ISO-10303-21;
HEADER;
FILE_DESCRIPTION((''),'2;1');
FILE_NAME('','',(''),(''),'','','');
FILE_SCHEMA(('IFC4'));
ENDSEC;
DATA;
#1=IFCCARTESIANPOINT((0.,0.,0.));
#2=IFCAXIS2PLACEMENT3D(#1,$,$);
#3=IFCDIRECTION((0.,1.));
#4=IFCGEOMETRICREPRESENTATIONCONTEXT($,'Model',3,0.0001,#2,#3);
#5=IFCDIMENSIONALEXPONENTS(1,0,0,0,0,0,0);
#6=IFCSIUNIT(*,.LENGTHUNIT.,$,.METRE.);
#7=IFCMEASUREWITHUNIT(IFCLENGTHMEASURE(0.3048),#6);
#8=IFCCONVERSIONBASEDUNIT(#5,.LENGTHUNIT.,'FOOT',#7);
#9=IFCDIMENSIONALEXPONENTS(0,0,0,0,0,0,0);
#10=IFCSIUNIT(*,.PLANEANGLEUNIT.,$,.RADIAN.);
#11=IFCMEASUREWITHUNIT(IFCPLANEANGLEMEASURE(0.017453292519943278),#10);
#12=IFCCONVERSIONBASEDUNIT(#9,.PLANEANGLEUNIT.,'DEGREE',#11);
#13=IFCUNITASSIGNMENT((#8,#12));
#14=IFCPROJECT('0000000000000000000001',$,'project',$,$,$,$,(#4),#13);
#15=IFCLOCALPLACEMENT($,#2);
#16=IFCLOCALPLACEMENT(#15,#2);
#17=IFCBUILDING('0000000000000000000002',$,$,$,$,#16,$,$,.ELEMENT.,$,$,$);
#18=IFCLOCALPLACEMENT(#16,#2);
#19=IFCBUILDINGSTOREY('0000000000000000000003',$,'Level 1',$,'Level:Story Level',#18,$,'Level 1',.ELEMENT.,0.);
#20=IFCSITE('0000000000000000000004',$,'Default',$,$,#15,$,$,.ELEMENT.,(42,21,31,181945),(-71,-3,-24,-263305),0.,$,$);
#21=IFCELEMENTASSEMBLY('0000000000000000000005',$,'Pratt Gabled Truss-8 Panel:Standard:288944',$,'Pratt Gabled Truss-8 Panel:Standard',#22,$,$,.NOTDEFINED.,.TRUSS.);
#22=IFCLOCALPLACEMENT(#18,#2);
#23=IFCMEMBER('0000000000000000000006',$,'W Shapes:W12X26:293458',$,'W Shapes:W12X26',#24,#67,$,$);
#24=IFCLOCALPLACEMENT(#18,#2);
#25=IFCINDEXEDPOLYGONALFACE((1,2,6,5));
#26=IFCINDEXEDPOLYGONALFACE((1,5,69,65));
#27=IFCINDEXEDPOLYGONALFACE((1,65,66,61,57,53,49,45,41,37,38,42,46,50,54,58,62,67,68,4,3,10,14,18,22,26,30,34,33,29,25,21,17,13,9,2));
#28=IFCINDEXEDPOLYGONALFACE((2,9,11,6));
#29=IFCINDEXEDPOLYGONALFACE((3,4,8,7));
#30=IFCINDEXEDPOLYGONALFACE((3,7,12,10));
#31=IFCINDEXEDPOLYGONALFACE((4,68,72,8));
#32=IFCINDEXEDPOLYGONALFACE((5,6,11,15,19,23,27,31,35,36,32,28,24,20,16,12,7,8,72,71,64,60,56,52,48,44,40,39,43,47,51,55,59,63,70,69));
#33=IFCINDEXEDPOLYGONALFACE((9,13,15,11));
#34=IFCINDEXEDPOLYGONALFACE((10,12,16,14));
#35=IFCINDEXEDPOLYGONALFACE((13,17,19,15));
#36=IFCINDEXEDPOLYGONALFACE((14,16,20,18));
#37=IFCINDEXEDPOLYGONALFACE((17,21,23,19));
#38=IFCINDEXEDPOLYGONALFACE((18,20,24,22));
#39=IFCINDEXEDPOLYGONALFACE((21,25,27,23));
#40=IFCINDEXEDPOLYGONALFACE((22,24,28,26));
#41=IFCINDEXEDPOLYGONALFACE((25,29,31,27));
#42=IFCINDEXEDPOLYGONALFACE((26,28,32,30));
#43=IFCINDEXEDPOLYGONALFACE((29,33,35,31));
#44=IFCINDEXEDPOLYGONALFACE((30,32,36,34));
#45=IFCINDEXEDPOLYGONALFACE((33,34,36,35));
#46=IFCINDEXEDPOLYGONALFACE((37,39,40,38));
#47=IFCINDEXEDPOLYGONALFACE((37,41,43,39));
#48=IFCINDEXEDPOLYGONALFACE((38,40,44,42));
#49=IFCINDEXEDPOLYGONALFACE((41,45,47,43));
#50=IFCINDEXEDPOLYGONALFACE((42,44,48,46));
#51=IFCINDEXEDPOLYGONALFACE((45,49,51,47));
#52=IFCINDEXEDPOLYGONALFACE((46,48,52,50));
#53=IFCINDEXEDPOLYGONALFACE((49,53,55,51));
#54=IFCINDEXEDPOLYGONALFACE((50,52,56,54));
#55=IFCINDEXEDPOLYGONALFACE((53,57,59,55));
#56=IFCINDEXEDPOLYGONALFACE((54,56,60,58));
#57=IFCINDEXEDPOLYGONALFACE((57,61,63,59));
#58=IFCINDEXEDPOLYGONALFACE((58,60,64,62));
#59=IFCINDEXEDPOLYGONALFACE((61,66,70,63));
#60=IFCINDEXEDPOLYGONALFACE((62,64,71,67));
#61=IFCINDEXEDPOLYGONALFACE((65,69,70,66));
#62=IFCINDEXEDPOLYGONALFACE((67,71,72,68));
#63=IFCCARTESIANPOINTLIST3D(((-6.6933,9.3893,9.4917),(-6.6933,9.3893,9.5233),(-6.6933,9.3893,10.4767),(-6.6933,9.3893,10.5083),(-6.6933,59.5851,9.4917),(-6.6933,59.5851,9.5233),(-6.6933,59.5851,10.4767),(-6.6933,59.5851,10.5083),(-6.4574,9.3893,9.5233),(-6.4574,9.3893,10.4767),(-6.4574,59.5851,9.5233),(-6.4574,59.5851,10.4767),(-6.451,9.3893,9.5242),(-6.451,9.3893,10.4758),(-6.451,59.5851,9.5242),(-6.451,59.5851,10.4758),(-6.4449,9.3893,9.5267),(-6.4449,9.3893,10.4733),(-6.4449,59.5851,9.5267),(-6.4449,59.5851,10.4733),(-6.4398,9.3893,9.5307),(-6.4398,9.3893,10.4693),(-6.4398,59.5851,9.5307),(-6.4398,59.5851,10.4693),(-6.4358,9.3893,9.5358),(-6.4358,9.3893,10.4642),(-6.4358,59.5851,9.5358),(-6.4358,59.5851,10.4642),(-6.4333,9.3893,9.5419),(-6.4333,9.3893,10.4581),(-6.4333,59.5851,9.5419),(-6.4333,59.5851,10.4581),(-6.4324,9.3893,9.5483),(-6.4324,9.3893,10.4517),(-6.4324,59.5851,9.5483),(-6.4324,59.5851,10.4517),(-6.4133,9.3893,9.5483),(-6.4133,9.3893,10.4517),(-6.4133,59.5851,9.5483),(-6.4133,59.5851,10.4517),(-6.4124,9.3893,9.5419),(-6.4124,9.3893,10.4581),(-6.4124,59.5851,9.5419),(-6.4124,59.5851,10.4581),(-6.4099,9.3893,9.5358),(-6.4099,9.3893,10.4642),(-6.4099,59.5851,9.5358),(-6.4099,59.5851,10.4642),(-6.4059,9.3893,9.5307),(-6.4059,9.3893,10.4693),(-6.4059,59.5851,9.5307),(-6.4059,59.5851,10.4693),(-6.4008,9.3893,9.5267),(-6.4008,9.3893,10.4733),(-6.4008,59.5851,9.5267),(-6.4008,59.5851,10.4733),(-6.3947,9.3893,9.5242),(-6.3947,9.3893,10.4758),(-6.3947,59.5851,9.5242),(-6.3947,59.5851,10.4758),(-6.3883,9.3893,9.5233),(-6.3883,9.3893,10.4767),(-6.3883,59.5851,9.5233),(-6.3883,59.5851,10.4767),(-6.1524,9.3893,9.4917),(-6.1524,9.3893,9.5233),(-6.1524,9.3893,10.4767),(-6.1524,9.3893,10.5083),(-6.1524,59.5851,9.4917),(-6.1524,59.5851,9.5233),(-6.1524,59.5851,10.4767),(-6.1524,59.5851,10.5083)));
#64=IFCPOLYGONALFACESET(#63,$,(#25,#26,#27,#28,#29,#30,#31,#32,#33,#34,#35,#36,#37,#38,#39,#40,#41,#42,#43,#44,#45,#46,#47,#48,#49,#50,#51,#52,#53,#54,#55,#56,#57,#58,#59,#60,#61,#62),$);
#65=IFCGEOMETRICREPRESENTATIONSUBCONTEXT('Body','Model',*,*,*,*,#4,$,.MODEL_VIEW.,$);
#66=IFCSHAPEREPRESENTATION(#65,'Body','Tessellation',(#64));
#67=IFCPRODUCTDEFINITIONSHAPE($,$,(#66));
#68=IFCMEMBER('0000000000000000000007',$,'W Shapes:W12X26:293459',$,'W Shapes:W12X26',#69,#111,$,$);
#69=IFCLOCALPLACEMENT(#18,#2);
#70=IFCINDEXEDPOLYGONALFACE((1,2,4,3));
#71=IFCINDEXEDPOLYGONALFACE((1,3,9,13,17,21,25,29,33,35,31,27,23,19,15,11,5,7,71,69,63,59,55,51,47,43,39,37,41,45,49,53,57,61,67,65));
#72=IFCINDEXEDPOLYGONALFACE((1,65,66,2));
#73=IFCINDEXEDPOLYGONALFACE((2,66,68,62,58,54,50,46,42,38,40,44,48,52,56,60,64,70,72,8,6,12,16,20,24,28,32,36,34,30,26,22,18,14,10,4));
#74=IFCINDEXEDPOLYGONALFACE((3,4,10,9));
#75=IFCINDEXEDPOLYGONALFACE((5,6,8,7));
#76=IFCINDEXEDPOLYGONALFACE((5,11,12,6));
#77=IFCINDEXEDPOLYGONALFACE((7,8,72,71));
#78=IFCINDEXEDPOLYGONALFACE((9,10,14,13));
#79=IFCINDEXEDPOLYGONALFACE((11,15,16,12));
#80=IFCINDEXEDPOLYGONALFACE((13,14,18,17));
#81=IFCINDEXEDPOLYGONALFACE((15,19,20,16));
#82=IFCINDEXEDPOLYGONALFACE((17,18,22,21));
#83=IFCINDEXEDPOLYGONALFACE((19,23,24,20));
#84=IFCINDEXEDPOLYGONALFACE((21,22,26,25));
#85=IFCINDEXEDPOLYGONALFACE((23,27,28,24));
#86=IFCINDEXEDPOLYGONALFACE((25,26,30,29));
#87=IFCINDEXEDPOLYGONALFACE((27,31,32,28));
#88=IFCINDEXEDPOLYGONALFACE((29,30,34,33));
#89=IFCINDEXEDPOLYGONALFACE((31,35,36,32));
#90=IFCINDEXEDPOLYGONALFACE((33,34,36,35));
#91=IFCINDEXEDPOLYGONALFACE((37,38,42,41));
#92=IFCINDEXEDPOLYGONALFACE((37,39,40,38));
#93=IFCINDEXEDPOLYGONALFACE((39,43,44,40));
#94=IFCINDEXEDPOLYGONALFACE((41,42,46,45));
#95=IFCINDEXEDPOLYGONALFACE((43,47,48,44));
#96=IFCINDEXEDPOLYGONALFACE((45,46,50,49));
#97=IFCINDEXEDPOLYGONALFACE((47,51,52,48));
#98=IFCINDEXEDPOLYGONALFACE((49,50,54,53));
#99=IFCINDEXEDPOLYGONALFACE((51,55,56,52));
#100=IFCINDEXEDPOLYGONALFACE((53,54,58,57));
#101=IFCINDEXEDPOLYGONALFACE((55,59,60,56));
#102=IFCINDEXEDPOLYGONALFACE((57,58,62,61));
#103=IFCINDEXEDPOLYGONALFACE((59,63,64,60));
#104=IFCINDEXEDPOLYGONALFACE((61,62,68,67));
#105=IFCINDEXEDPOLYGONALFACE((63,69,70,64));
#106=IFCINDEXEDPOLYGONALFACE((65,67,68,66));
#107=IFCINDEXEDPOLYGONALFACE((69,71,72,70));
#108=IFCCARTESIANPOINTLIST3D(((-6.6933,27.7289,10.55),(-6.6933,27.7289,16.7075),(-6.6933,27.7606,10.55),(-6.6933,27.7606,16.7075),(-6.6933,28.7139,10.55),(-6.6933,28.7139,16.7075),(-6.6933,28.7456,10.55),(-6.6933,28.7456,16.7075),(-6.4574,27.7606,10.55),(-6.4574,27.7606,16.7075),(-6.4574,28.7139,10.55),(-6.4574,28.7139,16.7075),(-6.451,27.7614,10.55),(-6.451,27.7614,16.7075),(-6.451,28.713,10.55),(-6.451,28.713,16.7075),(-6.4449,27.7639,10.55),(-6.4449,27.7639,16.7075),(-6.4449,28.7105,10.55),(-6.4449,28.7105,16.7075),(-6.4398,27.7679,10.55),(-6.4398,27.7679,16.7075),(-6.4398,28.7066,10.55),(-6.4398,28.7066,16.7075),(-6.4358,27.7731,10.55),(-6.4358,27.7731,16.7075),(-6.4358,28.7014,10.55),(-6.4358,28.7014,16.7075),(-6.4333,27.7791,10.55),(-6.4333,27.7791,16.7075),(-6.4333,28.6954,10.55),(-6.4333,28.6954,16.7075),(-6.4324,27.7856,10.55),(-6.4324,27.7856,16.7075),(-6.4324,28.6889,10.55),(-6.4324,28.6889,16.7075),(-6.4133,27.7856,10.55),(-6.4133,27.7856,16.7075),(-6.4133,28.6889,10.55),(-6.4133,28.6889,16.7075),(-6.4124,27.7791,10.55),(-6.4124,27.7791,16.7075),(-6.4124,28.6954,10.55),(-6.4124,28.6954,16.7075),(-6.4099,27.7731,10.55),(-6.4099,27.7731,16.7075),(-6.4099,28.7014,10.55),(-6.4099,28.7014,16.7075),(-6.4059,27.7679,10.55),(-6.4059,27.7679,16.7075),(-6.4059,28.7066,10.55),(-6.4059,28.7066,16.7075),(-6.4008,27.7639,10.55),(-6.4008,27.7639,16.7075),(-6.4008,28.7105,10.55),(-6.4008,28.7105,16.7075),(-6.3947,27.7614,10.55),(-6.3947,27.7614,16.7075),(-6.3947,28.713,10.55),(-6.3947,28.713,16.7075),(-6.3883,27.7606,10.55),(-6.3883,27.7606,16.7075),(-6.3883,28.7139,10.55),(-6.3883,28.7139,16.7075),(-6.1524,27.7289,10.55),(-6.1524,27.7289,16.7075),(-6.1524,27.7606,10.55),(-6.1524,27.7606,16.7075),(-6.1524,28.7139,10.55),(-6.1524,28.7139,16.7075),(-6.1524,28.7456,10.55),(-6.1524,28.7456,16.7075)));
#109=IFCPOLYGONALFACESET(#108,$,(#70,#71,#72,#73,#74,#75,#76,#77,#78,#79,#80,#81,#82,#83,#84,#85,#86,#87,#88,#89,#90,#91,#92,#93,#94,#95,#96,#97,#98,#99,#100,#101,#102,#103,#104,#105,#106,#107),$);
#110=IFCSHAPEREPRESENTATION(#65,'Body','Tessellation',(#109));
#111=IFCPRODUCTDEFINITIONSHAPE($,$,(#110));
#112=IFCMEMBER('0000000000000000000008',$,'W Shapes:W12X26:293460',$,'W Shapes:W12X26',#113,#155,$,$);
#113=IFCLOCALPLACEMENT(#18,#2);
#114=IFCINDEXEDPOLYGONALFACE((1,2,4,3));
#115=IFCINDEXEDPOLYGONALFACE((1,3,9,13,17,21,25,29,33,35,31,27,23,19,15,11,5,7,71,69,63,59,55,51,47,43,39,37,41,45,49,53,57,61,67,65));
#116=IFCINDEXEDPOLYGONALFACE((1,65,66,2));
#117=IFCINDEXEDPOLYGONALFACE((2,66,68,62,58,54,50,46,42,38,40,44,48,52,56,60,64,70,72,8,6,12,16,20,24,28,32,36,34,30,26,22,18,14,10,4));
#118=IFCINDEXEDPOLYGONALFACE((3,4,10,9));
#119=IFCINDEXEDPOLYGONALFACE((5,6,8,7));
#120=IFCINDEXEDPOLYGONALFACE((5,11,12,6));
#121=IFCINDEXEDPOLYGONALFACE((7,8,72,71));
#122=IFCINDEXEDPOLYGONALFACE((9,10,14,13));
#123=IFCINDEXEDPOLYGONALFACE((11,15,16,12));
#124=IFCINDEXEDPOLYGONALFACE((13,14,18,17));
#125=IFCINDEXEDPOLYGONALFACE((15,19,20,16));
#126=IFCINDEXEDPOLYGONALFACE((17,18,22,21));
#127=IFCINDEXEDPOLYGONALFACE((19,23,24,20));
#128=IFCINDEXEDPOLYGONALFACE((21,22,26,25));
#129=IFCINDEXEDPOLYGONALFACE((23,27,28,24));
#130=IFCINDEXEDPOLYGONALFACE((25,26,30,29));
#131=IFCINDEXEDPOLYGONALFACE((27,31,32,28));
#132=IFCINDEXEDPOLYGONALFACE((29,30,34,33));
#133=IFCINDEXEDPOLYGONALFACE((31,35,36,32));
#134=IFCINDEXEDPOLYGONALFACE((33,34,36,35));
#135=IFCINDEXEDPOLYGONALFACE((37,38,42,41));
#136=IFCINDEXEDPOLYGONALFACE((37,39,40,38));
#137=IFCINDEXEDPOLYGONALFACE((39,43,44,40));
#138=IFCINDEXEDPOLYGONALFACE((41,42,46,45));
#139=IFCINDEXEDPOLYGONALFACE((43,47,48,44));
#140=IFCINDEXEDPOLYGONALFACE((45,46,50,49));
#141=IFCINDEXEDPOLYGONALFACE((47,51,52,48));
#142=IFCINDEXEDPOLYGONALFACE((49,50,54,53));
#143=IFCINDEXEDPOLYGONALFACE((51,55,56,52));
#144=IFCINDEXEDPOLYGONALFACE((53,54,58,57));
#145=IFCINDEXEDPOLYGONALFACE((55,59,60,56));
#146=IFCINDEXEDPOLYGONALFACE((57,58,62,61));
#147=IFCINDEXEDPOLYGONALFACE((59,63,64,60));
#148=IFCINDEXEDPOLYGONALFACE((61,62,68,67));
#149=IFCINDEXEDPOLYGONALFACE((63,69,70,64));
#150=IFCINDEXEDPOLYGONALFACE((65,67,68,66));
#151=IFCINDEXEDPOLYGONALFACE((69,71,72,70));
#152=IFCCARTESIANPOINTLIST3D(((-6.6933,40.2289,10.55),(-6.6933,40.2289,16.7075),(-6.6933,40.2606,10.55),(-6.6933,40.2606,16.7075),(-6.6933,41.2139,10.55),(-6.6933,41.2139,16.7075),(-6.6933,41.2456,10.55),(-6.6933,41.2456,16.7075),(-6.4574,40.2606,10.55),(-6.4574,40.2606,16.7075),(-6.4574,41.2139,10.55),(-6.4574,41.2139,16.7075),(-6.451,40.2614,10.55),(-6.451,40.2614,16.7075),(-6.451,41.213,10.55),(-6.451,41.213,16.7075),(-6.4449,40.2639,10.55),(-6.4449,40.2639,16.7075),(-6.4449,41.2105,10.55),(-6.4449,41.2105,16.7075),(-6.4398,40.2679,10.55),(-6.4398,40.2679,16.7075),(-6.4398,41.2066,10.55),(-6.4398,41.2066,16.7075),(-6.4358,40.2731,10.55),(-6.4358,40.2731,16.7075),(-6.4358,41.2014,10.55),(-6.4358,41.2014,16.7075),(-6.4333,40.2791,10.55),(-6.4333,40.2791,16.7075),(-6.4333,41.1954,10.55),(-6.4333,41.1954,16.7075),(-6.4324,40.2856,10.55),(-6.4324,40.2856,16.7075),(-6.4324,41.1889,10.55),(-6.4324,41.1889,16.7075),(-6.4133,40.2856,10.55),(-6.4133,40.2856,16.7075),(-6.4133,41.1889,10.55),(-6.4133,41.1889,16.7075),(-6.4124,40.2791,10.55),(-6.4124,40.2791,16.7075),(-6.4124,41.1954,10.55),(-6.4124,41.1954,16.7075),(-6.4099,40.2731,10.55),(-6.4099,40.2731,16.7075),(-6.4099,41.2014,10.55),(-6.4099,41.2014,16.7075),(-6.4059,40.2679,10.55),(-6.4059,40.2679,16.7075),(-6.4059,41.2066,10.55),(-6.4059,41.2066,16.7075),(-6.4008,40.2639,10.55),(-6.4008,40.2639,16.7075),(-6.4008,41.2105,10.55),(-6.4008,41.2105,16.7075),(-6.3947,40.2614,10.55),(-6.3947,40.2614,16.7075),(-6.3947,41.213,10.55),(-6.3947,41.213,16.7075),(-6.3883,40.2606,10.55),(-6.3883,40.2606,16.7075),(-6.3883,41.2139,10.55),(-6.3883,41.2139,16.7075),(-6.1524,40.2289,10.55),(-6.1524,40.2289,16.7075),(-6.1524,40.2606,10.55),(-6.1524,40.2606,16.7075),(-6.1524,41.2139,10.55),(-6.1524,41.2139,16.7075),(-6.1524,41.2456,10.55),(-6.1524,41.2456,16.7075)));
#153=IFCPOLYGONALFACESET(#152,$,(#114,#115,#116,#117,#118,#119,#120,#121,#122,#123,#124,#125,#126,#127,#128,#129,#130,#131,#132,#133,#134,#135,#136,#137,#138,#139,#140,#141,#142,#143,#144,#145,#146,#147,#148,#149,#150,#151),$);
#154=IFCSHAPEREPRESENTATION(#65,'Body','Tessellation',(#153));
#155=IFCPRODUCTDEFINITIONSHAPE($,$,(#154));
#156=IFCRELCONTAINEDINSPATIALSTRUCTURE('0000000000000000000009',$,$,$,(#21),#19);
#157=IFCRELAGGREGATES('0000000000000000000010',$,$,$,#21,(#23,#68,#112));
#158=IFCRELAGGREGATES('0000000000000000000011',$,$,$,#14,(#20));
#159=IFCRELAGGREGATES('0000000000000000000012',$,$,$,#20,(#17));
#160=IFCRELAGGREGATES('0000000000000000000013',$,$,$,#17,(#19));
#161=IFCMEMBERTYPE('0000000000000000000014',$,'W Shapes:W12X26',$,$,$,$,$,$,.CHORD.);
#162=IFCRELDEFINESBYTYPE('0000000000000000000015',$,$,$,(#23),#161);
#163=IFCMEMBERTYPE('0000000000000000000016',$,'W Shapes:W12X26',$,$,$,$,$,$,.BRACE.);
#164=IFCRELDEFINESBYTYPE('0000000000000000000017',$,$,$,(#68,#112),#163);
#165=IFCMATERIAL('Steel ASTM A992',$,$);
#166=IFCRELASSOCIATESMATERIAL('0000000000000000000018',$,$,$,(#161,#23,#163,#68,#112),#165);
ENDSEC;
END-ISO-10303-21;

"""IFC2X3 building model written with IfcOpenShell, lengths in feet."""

from ifc_helpers import new_model, entity, si_unit, converted_unit, direction, frame, frame_2d, origin, place, context, subcontext, project, spatial, polyline, circle_curve, parameter, trimmed, segment, composite_curve, outline, extrude, source, transform, mapped, material, type_object, type_shapes, element, aggregate, save


model = new_model("IFC2X3")

# Units and contexts
model_context = context("Model", 3, precision=0.0001, world=origin(), true_north=direction((0.0, 1.0)))
body_context = subcontext(model_context, "Body", "Model", "MODEL_VIEW")
ifc_project = project(units=[converted_unit("LENGTHUNIT", "FOOT", entity("IfcLengthMeasure", 0.3048), si_unit("LENGTHUNIT", "METRE"), dimensions=[1, 0, 0, 0, 0, 0, 0]), converted_unit("PLANEANGLEUNIT", "DEGREE", entity("IfcPlaneAngleMeasure", 0.017453292519943278), si_unit("PLANEANGLEUNIT", "RADIAN"), dimensions=[0, 0, 0, 0, 0, 0, 0])], contexts=[model_context])

# Site, building, storey
site_placement = place(None, origin())
site = spatial("IfcSite", under=ifc_project, at=site_placement, Name="Default", CompositionType="ELEMENT", RefLatitude=(42, 21, 31, 181945), RefLongitude=(-71, -3, -24, -263305), RefElevation=0.0)
building_placement = place(site_placement, origin())
building = spatial("IfcBuilding", under=site, at=building_placement, CompositionType="ELEMENT")
storey_placement = place(building_placement, origin())
storey = spatial("IfcBuildingStorey", under=building, at=storey_placement, Name="Level 1", ObjectType="Level:Story Level", LongName="Level 1", CompositionType="ELEMENT", Elevation=0.0)

# Element assembly, members
assembly_placement = place(storey_placement, origin())
assembly = element("IfcElementAssembly", 1, at=assembly_placement, inside=storey, Name="Pratt Gabled Truss-8 Panel:Standard:288944", ObjectType="Pratt Gabled Truss-8 Panel:Standard", AssemblyPlace="NOTDEFINED", PredefinedType="TRUSS")
ifc_material = material(Name="Steel ASTM A992")
member_type_1 = type_object("IfcMemberType", Name="W Shapes:W12X26", PredefinedType="CHORD", material=ifc_material)
shared_shape_1 = source(origin(), body_context, "Body", "SweptSolid", [
    extrude(outline(composite_curve([segment(polyline([(-0.2704, -0.4767), (-0.2704, -0.5083)]), True, "CONTINUOUS"), segment(polyline([(-0.2704, -0.5083), (0.2704, -0.5083)]), True, "CONTINUOUS"), segment(polyline([(0.2704, -0.5083), (0.2704, -0.4767)]), True, "CONTINUOUS"), segment(polyline([(0.2704, -0.4767), (0.0346, -0.4767)]), True, "CONTINUOUS"), segment(trimmed(circle_curve(frame_2d((0.0346, -0.4517), x_axis=(1.0, 0.0)), 0.025), [parameter(180.0)], [parameter(270.0)], True, "PARAMETER"), False, "CONTINUOUS"), segment(polyline([(0.0096, -0.4517), (0.0096, 0.4517)]), True, "CONTINUOUS"), segment(trimmed(circle_curve(frame_2d((0.0346, 0.4517), x_axis=(1.0, 0.0)), 0.025), [parameter(90.0)], [parameter(180.0)], True, "PARAMETER"), False, "CONTINUOUS"), segment(polyline([(0.0346, 0.4767), (0.2704, 0.4767)]), True, "CONTINUOUS"), segment(polyline([(0.2704, 0.4767), (0.2704, 0.5083)]), True, "CONTINUOUS"), segment(polyline([(0.2704, 0.5083), (-0.2704, 0.5083)]), True, "CONTINUOUS"), segment(polyline([(-0.2704, 0.5083), (-0.2704, 0.4767)]), True, "CONTINUOUS"), segment(polyline([(-0.2704, 0.4767), (-0.0346, 0.4767)]), True, "CONTINUOUS"), segment(trimmed(circle_curve(frame_2d((-0.0346, 0.4517), x_axis=(1.0, 0.0)), 0.025), [parameter(360.0)], [parameter(90.0)], True, "PARAMETER"), False, "CONTINUOUS"), segment(polyline([(-0.0096, 0.4517), (-0.0096, -0.4517)]), True, "CONTINUOUS"), segment(trimmed(circle_curve(frame_2d((-0.0346, -0.4517), x_axis=(1.0, 0.0)), 0.025), [parameter(270.0)], [parameter(360.0)], True, "PARAMETER"), False, "CONTINUOUS"), segment(polyline([(-0.0346, -0.4767), (-0.2704, -0.4767)]), True, "CONTINUOUS")], self_intersect=False)), frame((-25.0979, 0.0, 0.0), z_axis=(-1.0, 0.0, 0.0), x_axis=(0.0, -1.0, 0.0)), (0.0, 0.0, -1.0), 50.1958),
])
type_shapes(member_type_1, [shared_shape_1])
member_1_placement = place(assembly_placement, frame((-6.4228, 34.4872, 10.0), z_axis=(0.0, 0.0, 1.0), x_axis=(0.0, 1.0, 0.0)))
member_1 = element("IfcMember", 2, at=member_1_placement, type_object=member_type_1, material=ifc_material, Name="W Shapes:W12X26:293458", ObjectType="W Shapes:W12X26", context=body_context, shape_type="MappedRepresentation", body=[
    mapped(shared_shape_1, transform((0.0, 0.0, 0.0), scale=1.0)),
])
member_type_2 = type_object("IfcMemberType", Name="W Shapes:W12X26", PredefinedType="BRACE", material=ifc_material)
shared_shape_2 = source(origin(), body_context, "Body", "SweptSolid", [
    extrude(outline(composite_curve([segment(polyline([(-0.2704, -0.4767), (-0.2704, -0.5083)]), True, "CONTINUOUS"), segment(polyline([(-0.2704, -0.5083), (0.2704, -0.5083)]), True, "CONTINUOUS"), segment(polyline([(0.2704, -0.5083), (0.2704, -0.4767)]), True, "CONTINUOUS"), segment(polyline([(0.2704, -0.4767), (0.0346, -0.4767)]), True, "CONTINUOUS"), segment(trimmed(circle_curve(frame_2d((0.0346, -0.4517), x_axis=(0.0, -1.0)), 0.025), [parameter(270.0)], [parameter(360.0)], True, "PARAMETER"), False, "CONTINUOUS"), segment(polyline([(0.0096, -0.4517), (0.0096, 0.4517)]), True, "CONTINUOUS"), segment(trimmed(circle_curve(frame_2d((0.0346, 0.4517), x_axis=(-1.0, 0.0)), 0.025), [parameter(270.0)], [parameter(360.0)], True, "PARAMETER"), False, "CONTINUOUS"), segment(polyline([(0.0346, 0.4767), (0.2704, 0.4767)]), True, "CONTINUOUS"), segment(polyline([(0.2704, 0.4767), (0.2704, 0.5083)]), True, "CONTINUOUS"), segment(polyline([(0.2704, 0.5083), (-0.2704, 0.5083)]), True, "CONTINUOUS"), segment(polyline([(-0.2704, 0.5083), (-0.2704, 0.4767)]), True, "CONTINUOUS"), segment(polyline([(-0.2704, 0.4767), (-0.0346, 0.4767)]), True, "CONTINUOUS"), segment(trimmed(circle_curve(frame_2d((-0.0346, 0.4517), x_axis=(0.0, 1.0)), 0.025), [parameter(270.0)], [parameter(0.0)], True, "PARAMETER"), False, "CONTINUOUS"), segment(polyline([(-0.0096, 0.4517), (-0.0096, -0.4517)]), True, "CONTINUOUS"), segment(trimmed(circle_curve(frame_2d((-0.0346, -0.4517), x_axis=(1.0, 0.0)), 0.025), [parameter(270.0)], [parameter(0.0)], True, "PARAMETER"), False, "CONTINUOUS"), segment(polyline([(-0.0346, -0.4767), (-0.2704, -0.4767)]), True, "CONTINUOUS")], self_intersect=False)), frame((-3.2, 0.0, 0.0), z_axis=(-1.0, 0.0, 0.0), x_axis=(0.0, -1.0, 0.0)), (0.0, 0.0, -1.0), 6.1575),
])
type_shapes(member_type_2, [shared_shape_2])
member_2_placement = place(assembly_placement, frame((-6.4228, 28.2372, 13.75), z_axis=(0.0, 1.0, 0.0), x_axis=(0.0, 0.0, 1.0)))
member_2 = element("IfcMember", 3, at=member_2_placement, type_object=member_type_2, material=ifc_material, Name="W Shapes:W12X26:293459", ObjectType="W Shapes:W12X26", context=body_context, shape_type="MappedRepresentation", body=[
    mapped(shared_shape_2, transform((0.0, 0.0, 0.0), scale=1.0)),
])
member_3_placement = place(assembly_placement, frame((-6.4228, 40.7372, 13.75), z_axis=(0.0, 1.0, 0.0), x_axis=(0.0, 0.0, 1.0)))
member_3 = element("IfcMember", 4, at=member_3_placement, type_object=member_type_2, material=ifc_material, Name="W Shapes:W12X26:293460", ObjectType="W Shapes:W12X26", context=body_context, shape_type="MappedRepresentation", body=[
    mapped(shared_shape_2, transform((0.0, 0.0, 0.0), scale=1.0)),
])
aggregate(assembly, [member_1, member_2, member_3])

save(model, "model.ifc")
